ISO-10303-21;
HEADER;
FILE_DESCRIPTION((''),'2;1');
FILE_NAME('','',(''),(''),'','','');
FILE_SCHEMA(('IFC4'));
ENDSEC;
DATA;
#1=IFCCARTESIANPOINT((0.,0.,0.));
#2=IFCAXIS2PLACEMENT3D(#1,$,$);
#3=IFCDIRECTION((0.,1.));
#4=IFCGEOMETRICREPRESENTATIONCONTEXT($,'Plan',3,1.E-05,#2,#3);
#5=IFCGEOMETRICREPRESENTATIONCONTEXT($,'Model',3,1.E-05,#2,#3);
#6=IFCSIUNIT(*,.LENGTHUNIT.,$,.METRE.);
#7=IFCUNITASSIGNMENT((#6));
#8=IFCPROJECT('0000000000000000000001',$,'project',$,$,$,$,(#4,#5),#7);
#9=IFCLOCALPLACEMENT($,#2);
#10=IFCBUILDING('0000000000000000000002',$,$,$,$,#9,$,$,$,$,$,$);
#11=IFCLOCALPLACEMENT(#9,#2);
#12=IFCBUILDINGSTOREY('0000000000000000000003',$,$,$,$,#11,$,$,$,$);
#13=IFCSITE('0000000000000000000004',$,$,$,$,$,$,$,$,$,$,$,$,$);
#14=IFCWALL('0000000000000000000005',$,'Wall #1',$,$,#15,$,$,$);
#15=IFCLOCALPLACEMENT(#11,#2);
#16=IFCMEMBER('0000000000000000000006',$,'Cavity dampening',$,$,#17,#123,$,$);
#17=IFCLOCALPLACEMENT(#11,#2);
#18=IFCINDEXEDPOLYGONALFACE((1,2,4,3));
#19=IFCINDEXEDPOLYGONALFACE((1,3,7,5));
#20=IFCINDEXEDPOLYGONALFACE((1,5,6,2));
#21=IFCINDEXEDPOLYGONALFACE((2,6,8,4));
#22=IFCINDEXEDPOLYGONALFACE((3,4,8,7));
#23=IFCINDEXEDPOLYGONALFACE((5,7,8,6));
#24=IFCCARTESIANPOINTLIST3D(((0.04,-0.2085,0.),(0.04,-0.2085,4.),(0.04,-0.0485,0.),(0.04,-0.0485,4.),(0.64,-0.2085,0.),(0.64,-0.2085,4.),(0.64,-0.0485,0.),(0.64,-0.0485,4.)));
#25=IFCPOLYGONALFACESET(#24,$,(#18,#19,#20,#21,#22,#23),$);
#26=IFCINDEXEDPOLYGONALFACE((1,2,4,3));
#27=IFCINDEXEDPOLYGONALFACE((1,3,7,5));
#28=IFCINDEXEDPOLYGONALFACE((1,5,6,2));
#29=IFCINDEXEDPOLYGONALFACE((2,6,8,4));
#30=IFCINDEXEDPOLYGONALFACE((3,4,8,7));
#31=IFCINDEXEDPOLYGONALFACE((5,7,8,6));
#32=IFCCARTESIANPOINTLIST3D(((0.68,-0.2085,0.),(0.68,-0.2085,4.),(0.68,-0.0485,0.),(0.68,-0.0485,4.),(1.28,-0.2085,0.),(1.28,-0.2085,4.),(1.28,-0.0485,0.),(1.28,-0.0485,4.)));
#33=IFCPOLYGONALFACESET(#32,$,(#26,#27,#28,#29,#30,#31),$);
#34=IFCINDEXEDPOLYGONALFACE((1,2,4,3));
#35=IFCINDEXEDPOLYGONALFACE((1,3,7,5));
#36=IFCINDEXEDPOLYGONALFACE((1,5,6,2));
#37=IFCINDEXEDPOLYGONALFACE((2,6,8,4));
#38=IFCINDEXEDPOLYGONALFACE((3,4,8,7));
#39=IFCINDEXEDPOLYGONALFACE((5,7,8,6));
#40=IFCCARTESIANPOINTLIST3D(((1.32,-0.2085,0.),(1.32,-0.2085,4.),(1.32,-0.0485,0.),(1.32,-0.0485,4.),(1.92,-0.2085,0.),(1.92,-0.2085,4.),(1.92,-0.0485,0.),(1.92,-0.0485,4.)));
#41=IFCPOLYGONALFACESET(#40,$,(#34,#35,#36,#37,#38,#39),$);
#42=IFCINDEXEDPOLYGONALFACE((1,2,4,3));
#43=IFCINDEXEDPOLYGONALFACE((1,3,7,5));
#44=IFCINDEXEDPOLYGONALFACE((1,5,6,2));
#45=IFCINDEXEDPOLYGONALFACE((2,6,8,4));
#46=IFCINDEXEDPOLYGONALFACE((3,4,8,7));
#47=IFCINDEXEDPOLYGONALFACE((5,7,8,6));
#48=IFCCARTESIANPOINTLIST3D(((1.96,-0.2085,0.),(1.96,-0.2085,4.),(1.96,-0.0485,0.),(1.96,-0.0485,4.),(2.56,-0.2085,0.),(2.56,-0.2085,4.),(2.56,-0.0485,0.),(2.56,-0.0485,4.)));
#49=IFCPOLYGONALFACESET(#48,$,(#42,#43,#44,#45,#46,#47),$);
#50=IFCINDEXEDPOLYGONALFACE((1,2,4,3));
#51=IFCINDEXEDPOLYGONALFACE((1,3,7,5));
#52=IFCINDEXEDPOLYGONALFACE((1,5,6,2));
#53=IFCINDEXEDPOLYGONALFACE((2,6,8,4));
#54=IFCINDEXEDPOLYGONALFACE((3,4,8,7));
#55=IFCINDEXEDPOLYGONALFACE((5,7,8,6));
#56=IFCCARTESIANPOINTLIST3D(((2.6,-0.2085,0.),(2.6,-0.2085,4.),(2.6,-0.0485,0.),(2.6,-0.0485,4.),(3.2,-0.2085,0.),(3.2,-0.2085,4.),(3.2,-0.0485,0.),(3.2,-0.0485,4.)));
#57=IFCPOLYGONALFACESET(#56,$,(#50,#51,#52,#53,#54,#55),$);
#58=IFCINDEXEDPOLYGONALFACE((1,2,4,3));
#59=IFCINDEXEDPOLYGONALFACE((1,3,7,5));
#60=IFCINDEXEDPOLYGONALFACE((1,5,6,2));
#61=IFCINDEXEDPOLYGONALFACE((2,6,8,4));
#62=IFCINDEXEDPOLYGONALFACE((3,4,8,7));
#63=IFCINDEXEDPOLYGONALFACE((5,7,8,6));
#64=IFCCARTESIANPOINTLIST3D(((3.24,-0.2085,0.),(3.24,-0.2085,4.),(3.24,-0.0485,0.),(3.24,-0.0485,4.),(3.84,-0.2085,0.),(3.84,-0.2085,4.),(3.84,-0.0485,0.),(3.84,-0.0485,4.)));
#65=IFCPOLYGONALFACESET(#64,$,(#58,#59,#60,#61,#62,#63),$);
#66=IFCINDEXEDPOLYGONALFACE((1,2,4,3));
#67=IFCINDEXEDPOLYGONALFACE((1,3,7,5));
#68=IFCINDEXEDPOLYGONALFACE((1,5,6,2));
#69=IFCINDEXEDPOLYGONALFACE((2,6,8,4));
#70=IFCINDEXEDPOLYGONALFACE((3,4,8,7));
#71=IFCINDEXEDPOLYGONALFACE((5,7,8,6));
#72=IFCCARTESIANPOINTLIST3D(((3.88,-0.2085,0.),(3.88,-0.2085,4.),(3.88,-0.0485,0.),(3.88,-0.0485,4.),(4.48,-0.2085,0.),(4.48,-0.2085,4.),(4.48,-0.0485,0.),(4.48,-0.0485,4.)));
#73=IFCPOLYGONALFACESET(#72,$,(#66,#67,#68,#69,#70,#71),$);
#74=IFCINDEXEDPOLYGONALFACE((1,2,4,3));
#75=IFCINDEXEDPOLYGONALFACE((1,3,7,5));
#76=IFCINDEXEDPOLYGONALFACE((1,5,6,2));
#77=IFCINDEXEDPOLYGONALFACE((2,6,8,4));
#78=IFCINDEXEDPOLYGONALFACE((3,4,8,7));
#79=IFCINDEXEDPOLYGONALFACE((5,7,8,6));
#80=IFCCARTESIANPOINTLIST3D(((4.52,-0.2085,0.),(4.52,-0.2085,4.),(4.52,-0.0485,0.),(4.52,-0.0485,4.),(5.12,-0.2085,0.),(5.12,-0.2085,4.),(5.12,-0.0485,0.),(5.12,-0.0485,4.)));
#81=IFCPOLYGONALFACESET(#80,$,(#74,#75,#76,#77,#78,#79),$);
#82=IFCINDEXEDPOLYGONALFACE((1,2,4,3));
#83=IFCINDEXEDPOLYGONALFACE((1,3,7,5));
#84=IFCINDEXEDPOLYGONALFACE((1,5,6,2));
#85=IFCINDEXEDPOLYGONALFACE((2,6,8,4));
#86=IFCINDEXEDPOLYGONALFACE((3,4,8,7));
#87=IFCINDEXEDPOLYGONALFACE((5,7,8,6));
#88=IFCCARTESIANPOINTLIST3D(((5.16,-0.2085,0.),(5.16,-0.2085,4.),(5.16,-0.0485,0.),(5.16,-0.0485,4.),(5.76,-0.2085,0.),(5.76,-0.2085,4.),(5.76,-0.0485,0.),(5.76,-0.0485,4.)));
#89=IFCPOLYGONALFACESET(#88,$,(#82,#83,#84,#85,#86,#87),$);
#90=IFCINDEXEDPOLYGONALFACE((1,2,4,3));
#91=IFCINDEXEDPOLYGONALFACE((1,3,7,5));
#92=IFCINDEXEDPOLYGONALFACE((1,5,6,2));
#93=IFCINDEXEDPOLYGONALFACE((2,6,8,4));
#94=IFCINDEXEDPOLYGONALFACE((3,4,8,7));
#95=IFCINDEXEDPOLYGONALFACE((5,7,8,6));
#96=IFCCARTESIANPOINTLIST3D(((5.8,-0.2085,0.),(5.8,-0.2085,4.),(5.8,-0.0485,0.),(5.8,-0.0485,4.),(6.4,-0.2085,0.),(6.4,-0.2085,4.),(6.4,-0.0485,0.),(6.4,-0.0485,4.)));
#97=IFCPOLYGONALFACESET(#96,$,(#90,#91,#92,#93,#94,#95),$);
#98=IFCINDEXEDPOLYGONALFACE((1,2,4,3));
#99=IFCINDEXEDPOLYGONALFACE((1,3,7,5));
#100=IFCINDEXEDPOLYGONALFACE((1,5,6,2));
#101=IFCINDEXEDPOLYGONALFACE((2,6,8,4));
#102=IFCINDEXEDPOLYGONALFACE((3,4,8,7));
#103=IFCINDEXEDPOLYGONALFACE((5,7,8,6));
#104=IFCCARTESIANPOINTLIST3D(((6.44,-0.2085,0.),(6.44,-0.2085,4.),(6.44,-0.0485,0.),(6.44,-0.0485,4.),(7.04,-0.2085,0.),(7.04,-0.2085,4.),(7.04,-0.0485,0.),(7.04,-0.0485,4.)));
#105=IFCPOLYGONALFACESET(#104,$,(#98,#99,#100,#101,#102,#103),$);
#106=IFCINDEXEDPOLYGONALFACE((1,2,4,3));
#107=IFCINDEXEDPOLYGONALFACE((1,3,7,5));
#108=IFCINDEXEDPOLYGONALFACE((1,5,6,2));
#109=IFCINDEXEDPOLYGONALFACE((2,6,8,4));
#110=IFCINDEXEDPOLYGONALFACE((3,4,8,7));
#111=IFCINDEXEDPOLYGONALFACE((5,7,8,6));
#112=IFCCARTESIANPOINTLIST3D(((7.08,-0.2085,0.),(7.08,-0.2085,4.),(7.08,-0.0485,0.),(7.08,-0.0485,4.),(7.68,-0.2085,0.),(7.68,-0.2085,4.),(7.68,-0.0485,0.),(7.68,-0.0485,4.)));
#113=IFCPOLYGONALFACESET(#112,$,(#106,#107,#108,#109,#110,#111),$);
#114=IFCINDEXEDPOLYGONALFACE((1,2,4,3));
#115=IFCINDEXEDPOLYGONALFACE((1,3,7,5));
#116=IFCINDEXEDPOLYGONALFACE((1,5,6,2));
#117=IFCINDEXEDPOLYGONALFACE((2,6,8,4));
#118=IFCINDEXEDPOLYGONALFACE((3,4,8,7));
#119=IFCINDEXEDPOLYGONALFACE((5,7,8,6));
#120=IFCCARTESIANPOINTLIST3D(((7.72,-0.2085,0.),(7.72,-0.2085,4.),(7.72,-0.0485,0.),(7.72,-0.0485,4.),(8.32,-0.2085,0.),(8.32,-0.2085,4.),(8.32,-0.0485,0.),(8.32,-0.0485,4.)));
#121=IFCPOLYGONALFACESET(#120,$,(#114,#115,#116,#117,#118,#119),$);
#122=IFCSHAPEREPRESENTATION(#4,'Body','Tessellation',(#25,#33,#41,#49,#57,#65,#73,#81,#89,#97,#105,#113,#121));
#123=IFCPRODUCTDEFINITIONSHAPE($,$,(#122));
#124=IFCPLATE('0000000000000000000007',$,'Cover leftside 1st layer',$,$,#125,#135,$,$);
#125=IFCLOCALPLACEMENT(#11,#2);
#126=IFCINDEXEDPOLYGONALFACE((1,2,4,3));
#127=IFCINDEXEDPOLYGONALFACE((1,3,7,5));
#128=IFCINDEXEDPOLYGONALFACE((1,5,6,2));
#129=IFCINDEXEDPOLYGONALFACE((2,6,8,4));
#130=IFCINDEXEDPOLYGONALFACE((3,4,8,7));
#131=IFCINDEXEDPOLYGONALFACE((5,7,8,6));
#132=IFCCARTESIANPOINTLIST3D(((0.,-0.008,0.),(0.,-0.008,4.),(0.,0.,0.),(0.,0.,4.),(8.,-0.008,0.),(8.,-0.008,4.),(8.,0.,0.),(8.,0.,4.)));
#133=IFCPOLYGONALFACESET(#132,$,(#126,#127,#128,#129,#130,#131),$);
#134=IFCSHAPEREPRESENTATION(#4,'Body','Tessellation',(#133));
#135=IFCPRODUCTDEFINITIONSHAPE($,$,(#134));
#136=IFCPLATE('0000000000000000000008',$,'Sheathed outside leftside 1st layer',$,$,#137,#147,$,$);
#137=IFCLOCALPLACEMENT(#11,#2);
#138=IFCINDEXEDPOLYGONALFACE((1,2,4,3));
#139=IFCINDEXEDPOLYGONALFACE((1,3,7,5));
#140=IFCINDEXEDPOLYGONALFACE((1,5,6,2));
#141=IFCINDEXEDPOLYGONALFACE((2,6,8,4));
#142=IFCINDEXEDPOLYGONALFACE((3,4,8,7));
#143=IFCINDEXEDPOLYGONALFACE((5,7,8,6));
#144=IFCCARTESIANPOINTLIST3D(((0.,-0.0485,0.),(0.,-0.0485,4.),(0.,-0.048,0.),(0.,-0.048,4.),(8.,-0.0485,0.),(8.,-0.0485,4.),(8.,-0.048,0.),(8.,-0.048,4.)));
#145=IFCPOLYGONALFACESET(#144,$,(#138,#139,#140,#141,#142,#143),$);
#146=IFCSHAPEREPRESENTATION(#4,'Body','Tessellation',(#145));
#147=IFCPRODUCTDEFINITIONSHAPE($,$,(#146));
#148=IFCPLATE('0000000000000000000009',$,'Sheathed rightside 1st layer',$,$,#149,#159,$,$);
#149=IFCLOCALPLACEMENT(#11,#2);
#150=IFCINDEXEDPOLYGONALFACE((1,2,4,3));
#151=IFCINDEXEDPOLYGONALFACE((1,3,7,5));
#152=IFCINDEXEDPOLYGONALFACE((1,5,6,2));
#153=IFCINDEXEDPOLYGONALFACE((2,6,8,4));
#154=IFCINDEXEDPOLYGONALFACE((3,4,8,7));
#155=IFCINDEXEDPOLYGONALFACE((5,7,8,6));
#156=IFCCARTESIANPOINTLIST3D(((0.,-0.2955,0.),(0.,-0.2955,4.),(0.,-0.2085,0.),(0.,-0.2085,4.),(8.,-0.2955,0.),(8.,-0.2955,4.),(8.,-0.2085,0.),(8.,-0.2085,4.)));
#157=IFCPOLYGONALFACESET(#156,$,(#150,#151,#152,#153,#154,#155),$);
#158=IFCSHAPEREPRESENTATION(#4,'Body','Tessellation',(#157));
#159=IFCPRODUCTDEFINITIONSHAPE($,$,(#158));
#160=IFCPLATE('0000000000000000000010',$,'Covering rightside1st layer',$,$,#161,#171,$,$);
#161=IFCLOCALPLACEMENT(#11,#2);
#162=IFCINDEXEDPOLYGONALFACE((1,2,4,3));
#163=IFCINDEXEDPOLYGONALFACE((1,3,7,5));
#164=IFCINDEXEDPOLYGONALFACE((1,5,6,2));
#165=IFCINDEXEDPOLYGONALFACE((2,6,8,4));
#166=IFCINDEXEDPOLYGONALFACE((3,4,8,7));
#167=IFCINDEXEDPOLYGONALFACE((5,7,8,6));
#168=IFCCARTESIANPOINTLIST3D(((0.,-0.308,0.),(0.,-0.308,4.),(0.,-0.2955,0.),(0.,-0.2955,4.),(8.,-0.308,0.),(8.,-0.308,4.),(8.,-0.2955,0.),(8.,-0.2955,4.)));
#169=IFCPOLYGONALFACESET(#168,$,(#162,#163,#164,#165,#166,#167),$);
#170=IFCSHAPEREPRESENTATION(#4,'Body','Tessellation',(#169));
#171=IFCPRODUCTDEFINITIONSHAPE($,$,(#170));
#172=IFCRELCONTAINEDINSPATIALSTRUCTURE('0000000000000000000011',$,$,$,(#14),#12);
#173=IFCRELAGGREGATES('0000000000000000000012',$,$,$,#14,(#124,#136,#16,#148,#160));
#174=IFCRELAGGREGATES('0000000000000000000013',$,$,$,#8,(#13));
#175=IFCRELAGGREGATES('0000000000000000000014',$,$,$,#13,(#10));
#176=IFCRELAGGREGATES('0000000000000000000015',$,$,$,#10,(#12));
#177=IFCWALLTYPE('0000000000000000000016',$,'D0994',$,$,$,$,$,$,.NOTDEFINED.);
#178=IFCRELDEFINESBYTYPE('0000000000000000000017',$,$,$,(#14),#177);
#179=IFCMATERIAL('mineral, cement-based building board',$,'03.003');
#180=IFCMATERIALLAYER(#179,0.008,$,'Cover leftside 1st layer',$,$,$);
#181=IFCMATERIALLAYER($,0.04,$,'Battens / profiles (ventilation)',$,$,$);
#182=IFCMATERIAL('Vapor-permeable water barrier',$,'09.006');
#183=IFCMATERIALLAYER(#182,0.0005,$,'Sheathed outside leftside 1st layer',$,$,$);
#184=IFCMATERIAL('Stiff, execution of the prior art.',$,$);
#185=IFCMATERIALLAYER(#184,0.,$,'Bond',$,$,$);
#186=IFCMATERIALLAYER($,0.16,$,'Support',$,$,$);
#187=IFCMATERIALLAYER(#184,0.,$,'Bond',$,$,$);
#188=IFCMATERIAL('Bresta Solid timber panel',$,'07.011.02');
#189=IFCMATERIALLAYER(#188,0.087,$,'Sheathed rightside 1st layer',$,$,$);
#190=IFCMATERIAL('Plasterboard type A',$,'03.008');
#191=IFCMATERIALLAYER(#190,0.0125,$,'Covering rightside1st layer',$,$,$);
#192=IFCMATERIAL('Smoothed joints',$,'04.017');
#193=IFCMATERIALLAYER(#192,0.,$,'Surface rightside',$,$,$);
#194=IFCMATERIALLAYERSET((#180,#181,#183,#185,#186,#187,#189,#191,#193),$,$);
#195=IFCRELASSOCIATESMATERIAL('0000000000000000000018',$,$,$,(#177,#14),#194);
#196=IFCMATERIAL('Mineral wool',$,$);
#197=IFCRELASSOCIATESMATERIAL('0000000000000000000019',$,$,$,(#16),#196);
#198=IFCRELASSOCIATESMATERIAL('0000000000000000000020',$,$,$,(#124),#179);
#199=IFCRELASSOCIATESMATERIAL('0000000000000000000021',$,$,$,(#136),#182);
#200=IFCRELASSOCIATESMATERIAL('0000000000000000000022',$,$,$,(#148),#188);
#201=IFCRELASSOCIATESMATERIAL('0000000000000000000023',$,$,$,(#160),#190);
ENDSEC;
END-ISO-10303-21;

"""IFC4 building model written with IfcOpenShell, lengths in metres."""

from ifc_helpers import new_model, si_unit, direction, frame, frame_2d, origin, origin_with_axes, place, context, project, spatial, rectangle, extrude, material, layer, layer_set, type_object, element, aggregate, save


model = new_model("IFC4")

# Units and contexts
plan_context = context("Plan", 3, precision=1e-05, world=origin(), true_north=direction((0.0, 1.0)))
model_context = context("Model", 3, precision=1e-05, world=origin(), true_north=direction((0.0, 1.0)))
ifc_project = project(units=[si_unit("LENGTHUNIT", "METRE")], contexts=[plan_context, model_context])

# Site, building, storey
site = spatial("IfcSite", under=ifc_project)
building_placement = place(None, origin())
building = spatial("IfcBuilding", under=site, at=building_placement)
storey_placement = place(building_placement, origin())
storey = spatial("IfcBuildingStorey", under=building, at=storey_placement)

# Wall, member, plates
ifc_material_1 = material(Name="mineral, cement-based building board", Category="03.003")
ifc_layer_1 = layer(ifc_material_1, 0.008, Name="Cover leftside 1st layer")
ifc_layer_2 = layer(None, 0.04, Name="Battens / profiles (ventilation)")
ifc_material_2 = material(Name="Vapor-permeable water barrier", Category="09.006")
ifc_layer_3 = layer(ifc_material_2, 0.0005, Name="Sheathed outside leftside 1st layer")
ifc_material_3 = material(Name="Stiff, execution of the prior art.")
ifc_layer_4 = layer(ifc_material_3, 0.0, Name="Bond")
ifc_layer_5 = layer(None, 0.16, Name="Support")
ifc_layer_6 = layer(ifc_material_3, 0.0, Name="Bond")
ifc_material_4 = material(Name="Bresta Solid timber panel", Category="07.011.02")
ifc_layer_7 = layer(ifc_material_4, 0.087, Name="Sheathed rightside 1st layer")
ifc_material_5 = material(Name="Plasterboard type A", Category="03.008")
ifc_layer_8 = layer(ifc_material_5, 0.0125, Name="Covering rightside1st layer")
ifc_material_6 = material(Name="Smoothed joints", Category="04.017")
ifc_layer_9 = layer(ifc_material_6, 0.0, Name="Surface rightside")
ifc_layer_set = layer_set([ifc_layer_1, ifc_layer_2, ifc_layer_3, ifc_layer_4, ifc_layer_5, ifc_layer_6, ifc_layer_7, ifc_layer_8, ifc_layer_9])
wall_type = type_object("IfcWallType", Name="D0994", PredefinedType="NOTDEFINED", material=ifc_layer_set)
wall_placement = place(None, frame((0.0, 0.0, 0.0), z_axis=(0.0, -1.0, 0.0), x_axis=(1.0, 0.0, 0.0)))
wall = element("IfcWall", 1, at=wall_placement, inside=storey, type_object=wall_type, material=ifc_layer_set, Name="Wall #1")
ifc_material_7 = material(Name="Mineral wool")
member_1_placement = place(wall_placement, origin())
member_1 = element("IfcMember", 2, at=member_1_placement, material=ifc_material_7, Name="Cavity dampening", context=plan_context, shape_type="SweptSolid", body=[
    extrude(rectangle(XDim=0.6, YDim=0.16, at=frame_2d((0.3, 0.08), x_axis=(1.0, 0.0))), frame((0.04, 4.0, 0.0485), z_axis=(0.0, -1.0, 0.0), x_axis=(1.0, 0.0, 0.0)), (0.0, 0.0, 1.0), 4.0),
    extrude(rectangle(XDim=0.6, YDim=0.16, at=frame_2d((0.3, 0.08), x_axis=(1.0, 0.0))), frame((0.68, 4.0, 0.0485), z_axis=(0.0, -1.0, 0.0), x_axis=(1.0, 0.0, 0.0)), (0.0, 0.0, 1.0), 4.0),
    extrude(rectangle(XDim=0.6, YDim=0.16, at=frame_2d((0.3, 0.08), x_axis=(1.0, 0.0))), frame((1.32, 4.0, 0.0485), z_axis=(0.0, -1.0, 0.0), x_axis=(1.0, 0.0, 0.0)), (0.0, 0.0, 1.0), 4.0),
    extrude(rectangle(XDim=0.6, YDim=0.16, at=frame_2d((0.3, 0.08), x_axis=(1.0, 0.0))), frame((1.96, 4.0, 0.0485), z_axis=(0.0, -1.0, 0.0), x_axis=(1.0, 0.0, 0.0)), (0.0, 0.0, 1.0), 4.0),
    extrude(rectangle(XDim=0.6, YDim=0.16, at=frame_2d((0.3, 0.08), x_axis=(1.0, 0.0))), frame((2.6, 4.0, 0.0485), z_axis=(0.0, -1.0, 0.0), x_axis=(1.0, 0.0, 0.0)), (0.0, 0.0, 1.0), 4.0),
    extrude(rectangle(XDim=0.6, YDim=0.16, at=frame_2d((0.3, 0.08), x_axis=(1.0, 0.0))), frame((3.24, 4.0, 0.0485), z_axis=(0.0, -1.0, 0.0), x_axis=(1.0, 0.0, 0.0)), (0.0, 0.0, 1.0), 4.0),
    extrude(rectangle(XDim=0.6, YDim=0.16, at=frame_2d((0.3, 0.08), x_axis=(1.0, 0.0))), frame((3.88, 4.0, 0.0485), z_axis=(0.0, -1.0, 0.0), x_axis=(1.0, 0.0, 0.0)), (0.0, 0.0, 1.0), 4.0),
    extrude(rectangle(XDim=0.6, YDim=0.16, at=frame_2d((0.3, 0.08), x_axis=(1.0, 0.0))), frame((4.52, 4.0, 0.0485), z_axis=(0.0, -1.0, 0.0), x_axis=(1.0, 0.0, 0.0)), (0.0, 0.0, 1.0), 4.0),
    extrude(rectangle(XDim=0.6, YDim=0.16, at=frame_2d((0.3, 0.08), x_axis=(1.0, 0.0))), frame((5.16, 4.0, 0.0485), z_axis=(0.0, -1.0, 0.0), x_axis=(1.0, 0.0, 0.0)), (0.0, 0.0, 1.0), 4.0),
    extrude(rectangle(XDim=0.6, YDim=0.16, at=frame_2d((0.3, 0.08), x_axis=(1.0, 0.0))), frame((5.8, 4.0, 0.0485), z_axis=(0.0, -1.0, 0.0), x_axis=(1.0, 0.0, 0.0)), (0.0, 0.0, 1.0), 4.0),
    extrude(rectangle(XDim=0.6, YDim=0.16, at=frame_2d((0.3, 0.08), x_axis=(1.0, 0.0))), frame((6.44, 4.0, 0.0485), z_axis=(0.0, -1.0, 0.0), x_axis=(1.0, 0.0, 0.0)), (0.0, 0.0, 1.0), 4.0),
    extrude(rectangle(XDim=0.6, YDim=0.16, at=frame_2d((0.3, 0.08), x_axis=(1.0, 0.0))), frame((7.08, 4.0, 0.0485), z_axis=(0.0, -1.0, 0.0), x_axis=(1.0, 0.0, 0.0)), (0.0, 0.0, 1.0), 4.0),
    extrude(rectangle(XDim=0.6, YDim=0.16, at=frame_2d((0.3, 0.08), x_axis=(1.0, 0.0))), frame((7.72, 4.0, 0.0485), z_axis=(0.0, -1.0, 0.0), x_axis=(1.0, 0.0, 0.0)), (0.0, 0.0, 1.0), 4.0),
])
plate_1_placement = place(wall_placement, origin())
plate_1 = element("IfcPlate", 3, at=plate_1_placement, material=ifc_material_1, Name="Cover leftside 1st layer", context=plan_context, shape_type="SweptSolid", body=[
    extrude(rectangle(XDim=8.0, YDim=4.0, at=frame_2d((4.0, 2.0), x_axis=(1.0, 0.0))), origin_with_axes(), (0.0, 0.0, 1.0), 0.008),
])
plate_2_placement = place(wall_placement, origin())
plate_2 = element("IfcPlate", 4, at=plate_2_placement, material=ifc_material_2, Name="Sheathed outside leftside 1st layer", context=plan_context, shape_type="SweptSolid", body=[
    extrude(rectangle(XDim=8.0, YDim=4.0, at=frame_2d((4.0, 2.0), x_axis=(1.0, 0.0))), frame((0.0, 0.0, 0.048), z_axis=(0.0, 0.0, 1.0), x_axis=(1.0, 0.0, 0.0)), (0.0, 0.0, 1.0), 0.0005),
])
plate_3_placement = place(wall_placement, origin())
plate_3 = element("IfcPlate", 5, at=plate_3_placement, material=ifc_material_4, Name="Sheathed rightside 1st layer", context=plan_context, shape_type="SweptSolid", body=[
    extrude(rectangle(XDim=8.0, YDim=4.0, at=frame_2d((4.0, 2.0), x_axis=(1.0, 0.0))), frame((0.0, 0.0, 0.2085), z_axis=(0.0, 0.0, 1.0), x_axis=(1.0, 0.0, 0.0)), (0.0, 0.0, 1.0), 0.087),
])
plate_4_placement = place(wall_placement, origin())
plate_4 = element("IfcPlate", 6, at=plate_4_placement, material=ifc_material_5, Name="Covering rightside1st layer", context=plan_context, shape_type="SweptSolid", body=[
    extrude(rectangle(XDim=8.0, YDim=4.0, at=frame_2d((4.0, 2.0), x_axis=(1.0, 0.0))), frame((0.0, 0.0, 0.2955), z_axis=(0.0, 0.0, 1.0), x_axis=(1.0, 0.0, 0.0)), (0.0, 0.0, 1.0), 0.0125),
])
aggregate(wall, [plate_1, plate_2, member_1, plate_3, plate_4])

save(model, "model.ifc")
